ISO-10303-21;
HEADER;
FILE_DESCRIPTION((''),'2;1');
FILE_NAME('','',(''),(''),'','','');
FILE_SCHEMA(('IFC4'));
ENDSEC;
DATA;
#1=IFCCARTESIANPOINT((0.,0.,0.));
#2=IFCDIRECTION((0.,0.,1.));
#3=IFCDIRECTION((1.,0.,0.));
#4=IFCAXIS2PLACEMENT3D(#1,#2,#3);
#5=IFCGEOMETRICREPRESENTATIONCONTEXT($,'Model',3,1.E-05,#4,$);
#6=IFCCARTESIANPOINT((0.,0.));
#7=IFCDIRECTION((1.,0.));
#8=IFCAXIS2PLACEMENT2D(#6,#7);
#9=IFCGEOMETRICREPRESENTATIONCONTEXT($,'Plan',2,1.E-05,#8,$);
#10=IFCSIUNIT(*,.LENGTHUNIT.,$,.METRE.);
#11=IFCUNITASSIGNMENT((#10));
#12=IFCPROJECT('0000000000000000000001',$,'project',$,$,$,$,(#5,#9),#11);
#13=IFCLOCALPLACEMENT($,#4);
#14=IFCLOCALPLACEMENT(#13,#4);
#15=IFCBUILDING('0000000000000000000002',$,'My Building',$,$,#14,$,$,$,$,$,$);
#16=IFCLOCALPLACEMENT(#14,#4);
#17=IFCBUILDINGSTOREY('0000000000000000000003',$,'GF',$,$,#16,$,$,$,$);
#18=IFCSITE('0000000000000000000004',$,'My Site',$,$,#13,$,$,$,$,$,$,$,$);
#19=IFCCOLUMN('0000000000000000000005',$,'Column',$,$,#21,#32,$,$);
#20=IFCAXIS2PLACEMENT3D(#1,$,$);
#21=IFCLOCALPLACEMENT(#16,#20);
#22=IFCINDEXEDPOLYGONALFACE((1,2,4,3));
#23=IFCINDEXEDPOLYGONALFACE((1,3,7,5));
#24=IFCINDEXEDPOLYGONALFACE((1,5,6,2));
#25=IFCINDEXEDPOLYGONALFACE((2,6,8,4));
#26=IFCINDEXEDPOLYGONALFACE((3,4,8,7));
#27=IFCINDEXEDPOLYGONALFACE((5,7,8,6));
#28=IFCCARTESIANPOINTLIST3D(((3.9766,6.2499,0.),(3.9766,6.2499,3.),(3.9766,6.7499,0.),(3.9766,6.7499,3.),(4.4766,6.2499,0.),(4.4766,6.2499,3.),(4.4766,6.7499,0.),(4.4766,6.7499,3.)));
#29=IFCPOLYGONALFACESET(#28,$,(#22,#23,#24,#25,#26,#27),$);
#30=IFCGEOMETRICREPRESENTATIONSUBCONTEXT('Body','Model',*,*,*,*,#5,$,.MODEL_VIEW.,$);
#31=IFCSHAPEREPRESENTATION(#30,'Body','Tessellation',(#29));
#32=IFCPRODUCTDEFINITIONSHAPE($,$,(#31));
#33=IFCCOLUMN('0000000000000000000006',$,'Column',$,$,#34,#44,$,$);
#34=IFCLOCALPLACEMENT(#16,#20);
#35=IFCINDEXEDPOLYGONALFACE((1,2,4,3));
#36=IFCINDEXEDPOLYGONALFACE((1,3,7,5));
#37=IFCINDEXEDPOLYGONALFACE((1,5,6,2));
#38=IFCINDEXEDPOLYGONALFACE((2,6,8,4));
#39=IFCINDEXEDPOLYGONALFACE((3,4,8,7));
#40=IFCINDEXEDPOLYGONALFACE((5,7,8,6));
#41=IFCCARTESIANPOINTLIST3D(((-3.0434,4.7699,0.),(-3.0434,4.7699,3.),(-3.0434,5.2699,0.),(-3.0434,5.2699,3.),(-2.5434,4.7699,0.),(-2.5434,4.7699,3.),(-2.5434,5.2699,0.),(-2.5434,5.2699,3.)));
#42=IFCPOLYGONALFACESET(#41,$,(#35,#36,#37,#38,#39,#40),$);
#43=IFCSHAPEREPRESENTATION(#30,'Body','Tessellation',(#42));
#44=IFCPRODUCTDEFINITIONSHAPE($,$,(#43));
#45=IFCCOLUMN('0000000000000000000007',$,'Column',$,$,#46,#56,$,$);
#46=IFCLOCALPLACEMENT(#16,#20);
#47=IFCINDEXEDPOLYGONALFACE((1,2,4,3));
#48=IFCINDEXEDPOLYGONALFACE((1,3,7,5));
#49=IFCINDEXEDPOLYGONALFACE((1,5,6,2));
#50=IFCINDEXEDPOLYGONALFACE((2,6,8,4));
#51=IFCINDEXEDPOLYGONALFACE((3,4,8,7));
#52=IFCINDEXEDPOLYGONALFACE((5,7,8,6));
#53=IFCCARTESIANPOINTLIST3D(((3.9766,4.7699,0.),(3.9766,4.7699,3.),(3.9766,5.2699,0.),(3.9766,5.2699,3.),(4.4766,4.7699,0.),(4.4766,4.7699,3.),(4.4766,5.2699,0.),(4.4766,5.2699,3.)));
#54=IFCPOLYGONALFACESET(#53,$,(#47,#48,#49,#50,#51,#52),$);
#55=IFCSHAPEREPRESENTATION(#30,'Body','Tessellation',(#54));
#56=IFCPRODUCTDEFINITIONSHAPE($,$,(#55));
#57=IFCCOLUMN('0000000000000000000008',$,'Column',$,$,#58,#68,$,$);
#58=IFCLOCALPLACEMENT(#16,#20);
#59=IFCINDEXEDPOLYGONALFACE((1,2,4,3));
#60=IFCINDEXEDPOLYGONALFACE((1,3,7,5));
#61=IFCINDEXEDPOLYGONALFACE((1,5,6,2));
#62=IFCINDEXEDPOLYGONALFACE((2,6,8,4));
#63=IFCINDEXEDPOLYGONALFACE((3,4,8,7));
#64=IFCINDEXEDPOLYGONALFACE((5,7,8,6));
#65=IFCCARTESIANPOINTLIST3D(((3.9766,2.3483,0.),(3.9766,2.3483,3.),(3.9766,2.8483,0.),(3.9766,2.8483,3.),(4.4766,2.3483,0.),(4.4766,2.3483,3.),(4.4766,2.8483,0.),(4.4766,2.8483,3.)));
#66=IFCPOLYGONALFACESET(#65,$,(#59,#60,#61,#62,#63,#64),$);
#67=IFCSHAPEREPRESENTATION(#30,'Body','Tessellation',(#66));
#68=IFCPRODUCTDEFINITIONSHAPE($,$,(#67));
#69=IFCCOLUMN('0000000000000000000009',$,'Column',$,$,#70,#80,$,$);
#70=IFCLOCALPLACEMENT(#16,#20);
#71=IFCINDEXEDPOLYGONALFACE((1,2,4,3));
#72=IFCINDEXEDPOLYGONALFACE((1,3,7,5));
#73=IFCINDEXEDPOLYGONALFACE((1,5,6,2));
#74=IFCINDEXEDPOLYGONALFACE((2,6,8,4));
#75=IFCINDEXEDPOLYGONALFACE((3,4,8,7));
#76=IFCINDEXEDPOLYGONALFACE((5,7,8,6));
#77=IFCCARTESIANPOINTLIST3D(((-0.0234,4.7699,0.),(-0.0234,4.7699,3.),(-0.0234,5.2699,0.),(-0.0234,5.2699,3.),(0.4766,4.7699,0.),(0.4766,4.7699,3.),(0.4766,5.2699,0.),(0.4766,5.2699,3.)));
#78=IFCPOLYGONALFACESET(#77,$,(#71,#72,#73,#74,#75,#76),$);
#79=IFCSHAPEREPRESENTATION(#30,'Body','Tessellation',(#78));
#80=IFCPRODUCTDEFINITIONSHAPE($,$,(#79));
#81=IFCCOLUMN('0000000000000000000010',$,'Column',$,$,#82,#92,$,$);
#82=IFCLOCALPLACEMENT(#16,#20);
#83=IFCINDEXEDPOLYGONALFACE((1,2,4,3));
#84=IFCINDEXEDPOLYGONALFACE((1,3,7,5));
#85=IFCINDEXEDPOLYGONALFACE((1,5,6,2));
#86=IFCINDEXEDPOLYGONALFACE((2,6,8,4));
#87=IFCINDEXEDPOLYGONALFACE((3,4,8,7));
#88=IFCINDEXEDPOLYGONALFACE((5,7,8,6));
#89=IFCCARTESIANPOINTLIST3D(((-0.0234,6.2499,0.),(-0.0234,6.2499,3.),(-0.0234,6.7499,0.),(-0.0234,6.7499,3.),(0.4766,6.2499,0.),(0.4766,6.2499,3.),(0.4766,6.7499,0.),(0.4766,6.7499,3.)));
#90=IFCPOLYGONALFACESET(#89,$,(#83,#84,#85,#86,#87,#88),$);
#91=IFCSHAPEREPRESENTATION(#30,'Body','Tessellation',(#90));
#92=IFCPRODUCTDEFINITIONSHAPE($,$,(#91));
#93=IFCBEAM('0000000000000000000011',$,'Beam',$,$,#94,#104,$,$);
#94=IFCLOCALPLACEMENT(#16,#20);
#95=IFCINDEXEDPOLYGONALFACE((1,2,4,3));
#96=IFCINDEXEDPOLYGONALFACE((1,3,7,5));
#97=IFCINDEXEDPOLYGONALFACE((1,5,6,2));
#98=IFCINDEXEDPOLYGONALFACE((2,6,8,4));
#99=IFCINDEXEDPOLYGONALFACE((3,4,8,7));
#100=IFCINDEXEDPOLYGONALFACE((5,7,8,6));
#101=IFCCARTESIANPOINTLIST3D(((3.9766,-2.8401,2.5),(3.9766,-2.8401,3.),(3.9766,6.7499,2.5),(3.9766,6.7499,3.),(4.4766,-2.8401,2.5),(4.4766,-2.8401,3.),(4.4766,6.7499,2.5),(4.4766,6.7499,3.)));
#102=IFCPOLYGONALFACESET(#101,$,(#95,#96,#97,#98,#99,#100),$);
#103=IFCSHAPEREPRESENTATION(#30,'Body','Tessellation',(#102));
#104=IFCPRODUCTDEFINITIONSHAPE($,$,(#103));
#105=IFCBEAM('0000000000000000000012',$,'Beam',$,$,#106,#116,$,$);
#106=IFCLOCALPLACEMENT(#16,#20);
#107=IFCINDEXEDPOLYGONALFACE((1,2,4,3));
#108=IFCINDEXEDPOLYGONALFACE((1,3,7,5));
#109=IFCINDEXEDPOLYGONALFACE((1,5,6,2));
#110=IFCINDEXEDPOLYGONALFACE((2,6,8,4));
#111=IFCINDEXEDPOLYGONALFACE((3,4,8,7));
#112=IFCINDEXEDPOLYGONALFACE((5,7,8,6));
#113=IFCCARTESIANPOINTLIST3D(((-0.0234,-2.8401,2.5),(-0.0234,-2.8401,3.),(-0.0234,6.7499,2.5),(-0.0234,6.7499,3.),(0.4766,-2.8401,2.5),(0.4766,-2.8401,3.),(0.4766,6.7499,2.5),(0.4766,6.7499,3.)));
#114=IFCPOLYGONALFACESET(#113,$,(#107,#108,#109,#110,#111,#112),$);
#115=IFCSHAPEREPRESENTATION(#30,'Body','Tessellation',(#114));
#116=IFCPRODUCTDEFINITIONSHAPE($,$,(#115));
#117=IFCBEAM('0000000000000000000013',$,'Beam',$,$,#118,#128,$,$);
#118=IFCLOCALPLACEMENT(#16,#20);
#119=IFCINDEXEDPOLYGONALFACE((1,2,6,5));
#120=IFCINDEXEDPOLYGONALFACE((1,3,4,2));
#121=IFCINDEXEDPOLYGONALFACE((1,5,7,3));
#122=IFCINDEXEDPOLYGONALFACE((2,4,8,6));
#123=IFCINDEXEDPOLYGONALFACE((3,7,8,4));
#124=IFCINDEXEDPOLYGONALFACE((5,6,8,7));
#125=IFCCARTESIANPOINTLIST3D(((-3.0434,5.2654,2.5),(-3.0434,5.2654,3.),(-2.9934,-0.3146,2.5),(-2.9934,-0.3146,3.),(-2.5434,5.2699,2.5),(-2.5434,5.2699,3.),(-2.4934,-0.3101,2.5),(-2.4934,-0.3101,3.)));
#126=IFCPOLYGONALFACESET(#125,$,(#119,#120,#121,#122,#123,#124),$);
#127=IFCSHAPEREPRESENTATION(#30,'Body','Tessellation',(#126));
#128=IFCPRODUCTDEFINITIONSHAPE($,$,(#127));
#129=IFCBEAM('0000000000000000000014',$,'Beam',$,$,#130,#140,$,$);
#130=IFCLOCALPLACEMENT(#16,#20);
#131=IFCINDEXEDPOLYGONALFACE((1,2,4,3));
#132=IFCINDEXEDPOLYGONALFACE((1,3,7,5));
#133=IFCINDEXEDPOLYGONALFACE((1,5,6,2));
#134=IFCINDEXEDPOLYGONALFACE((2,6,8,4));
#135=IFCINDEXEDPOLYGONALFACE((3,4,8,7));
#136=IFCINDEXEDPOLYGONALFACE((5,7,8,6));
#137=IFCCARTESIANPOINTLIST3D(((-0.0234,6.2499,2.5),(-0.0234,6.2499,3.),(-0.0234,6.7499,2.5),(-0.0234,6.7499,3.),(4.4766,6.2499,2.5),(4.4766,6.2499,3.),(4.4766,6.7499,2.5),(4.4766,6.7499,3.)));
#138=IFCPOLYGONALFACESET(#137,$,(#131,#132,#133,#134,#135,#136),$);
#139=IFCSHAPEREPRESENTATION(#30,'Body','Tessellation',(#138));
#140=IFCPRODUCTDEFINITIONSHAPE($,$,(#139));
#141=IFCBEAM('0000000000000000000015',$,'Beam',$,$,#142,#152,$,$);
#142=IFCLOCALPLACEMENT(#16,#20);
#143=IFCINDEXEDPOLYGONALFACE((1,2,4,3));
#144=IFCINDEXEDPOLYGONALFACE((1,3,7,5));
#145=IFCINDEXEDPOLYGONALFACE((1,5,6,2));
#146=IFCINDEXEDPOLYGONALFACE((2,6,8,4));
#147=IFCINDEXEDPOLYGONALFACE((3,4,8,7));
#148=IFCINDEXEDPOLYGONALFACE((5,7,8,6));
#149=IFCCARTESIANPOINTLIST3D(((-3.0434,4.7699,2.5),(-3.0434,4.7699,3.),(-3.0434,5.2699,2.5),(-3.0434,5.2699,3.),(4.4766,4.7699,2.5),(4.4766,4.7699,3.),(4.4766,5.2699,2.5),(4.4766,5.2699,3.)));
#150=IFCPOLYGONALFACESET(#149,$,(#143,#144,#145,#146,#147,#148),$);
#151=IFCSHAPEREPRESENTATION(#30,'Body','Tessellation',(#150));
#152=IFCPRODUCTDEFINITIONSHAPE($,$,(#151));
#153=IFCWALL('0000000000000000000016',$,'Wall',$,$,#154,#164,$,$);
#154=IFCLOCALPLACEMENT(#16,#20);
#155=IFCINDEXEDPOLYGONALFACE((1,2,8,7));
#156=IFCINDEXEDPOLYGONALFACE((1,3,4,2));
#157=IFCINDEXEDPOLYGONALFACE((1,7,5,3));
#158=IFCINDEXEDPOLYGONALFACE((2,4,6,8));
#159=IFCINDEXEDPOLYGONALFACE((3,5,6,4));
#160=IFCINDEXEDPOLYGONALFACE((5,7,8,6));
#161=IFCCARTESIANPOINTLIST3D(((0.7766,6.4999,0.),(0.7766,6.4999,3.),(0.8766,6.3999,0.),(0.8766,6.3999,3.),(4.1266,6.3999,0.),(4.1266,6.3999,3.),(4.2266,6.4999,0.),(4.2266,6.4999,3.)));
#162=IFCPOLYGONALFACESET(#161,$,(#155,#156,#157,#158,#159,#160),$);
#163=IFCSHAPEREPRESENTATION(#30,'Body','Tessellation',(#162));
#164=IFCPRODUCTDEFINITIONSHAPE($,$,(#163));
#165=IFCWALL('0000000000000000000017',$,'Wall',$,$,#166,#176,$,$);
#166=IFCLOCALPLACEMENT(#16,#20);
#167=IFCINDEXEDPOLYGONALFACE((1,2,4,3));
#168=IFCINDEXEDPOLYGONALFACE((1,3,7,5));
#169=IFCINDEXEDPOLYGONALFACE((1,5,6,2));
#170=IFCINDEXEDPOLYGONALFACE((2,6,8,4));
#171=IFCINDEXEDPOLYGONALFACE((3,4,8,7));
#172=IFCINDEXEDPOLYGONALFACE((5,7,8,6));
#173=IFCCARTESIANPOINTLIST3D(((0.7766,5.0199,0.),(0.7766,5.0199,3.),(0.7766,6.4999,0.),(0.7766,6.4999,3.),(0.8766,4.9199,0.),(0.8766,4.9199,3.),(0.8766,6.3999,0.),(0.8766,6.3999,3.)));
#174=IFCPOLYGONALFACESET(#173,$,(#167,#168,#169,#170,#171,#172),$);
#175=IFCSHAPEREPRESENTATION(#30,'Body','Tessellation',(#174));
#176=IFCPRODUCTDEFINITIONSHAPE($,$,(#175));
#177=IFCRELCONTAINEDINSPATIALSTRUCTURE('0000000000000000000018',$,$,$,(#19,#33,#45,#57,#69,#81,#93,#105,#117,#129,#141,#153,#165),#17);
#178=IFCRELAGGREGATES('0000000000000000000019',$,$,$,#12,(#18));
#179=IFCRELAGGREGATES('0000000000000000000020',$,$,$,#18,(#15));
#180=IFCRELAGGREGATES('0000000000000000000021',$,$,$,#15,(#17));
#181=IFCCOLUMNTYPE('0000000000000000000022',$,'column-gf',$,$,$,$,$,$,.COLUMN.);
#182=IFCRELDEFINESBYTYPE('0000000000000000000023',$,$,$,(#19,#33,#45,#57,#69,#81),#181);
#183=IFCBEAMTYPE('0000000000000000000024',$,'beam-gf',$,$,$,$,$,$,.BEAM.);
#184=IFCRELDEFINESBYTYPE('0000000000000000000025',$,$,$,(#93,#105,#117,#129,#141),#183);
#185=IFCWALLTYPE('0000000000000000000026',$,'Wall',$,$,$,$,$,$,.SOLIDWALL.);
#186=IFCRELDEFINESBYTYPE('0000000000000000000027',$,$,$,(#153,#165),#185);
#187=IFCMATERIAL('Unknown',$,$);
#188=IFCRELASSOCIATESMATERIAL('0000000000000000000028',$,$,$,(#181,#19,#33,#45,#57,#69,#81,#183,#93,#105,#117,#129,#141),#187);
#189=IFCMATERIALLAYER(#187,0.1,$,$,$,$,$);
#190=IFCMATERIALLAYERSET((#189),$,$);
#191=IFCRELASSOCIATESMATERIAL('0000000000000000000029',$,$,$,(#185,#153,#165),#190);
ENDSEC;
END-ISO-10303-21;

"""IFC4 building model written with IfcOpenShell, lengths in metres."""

from ifc_helpers import new_model, si_unit, frame, origin_with_axes, origin_2d_with_axis, place, context, subcontext, project, spatial, line, indexed_curve, rectangle, outline, extrude, material, layer, layer_set, layer_usage, material_profile, profile_set, profile_usage, type_object, element, save


model = new_model("IFC4")

# Units and contexts
model_context = context("Model", 3, precision=1e-05, world=origin_with_axes())
plan_context = context("Plan", 2, precision=1e-05, world=origin_2d_with_axis())
body_context_1 = subcontext(model_context, "Body", "Model", "MODEL_VIEW")
ifc_project = project(units=[si_unit("LENGTHUNIT", "METRE")], contexts=[model_context, plan_context])

# Site, building, storey
site_placement = place(None, origin_with_axes())
site = spatial("IfcSite", under=ifc_project, at=site_placement, Name="My Site")
building_placement = place(site_placement, origin_with_axes())
building = spatial("IfcBuilding", under=site, at=building_placement, Name="My Building")
storey_placement = place(building_placement, origin_with_axes())
storey = spatial("IfcBuildingStorey", under=building, at=storey_placement, Name="GF")

# Columns
ifc_material_1 = material(Name="Unknown")
ifc_material_profile_1 = material_profile(ifc_material_1, rectangle(XDim=0.5, YDim=0.5))
ifc_profile_set_1 = profile_set([ifc_material_profile_1])
ifc_profile_usage_1 = profile_usage(ifc_profile_set_1, cardinal=5)
column_type = type_object("IfcColumnType", Name="column-gf", PredefinedType="COLUMN", material=ifc_profile_set_1)
column_1_placement = place(storey_placement, frame((4.2266, 6.4999, 0.0), z_axis=(0.0, 0.0, 1.0), x_axis=(1.0, 0.0, 0.0)))
element("IfcColumn", 1, at=column_1_placement, inside=storey, type_object=column_type, material=ifc_profile_usage_1, Name="Column", context=body_context_1, shape_type="SweptSolid", body=[
    extrude(rectangle(XDim=0.5, YDim=0.5), origin_with_axes(), (0.0, 0.0, 1.0), 3.0),
])
ifc_profile_usage_2 = profile_usage(ifc_profile_set_1, cardinal=5)
column_2_placement = place(storey_placement, frame((-2.7934, 5.0199, 0.0), z_axis=(0.0, 0.0, 1.0), x_axis=(1.0, 0.0, 0.0)))
element("IfcColumn", 2, at=column_2_placement, inside=storey, type_object=column_type, material=ifc_profile_usage_2, Name="Column", context=body_context_1, shape_type="SweptSolid", body=[
    extrude(rectangle(XDim=0.5, YDim=0.5), origin_with_axes(), (0.0, 0.0, 1.0), 3.0),
])
ifc_profile_usage_3 = profile_usage(ifc_profile_set_1, cardinal=5)
column_3_placement = place(storey_placement, frame((4.2266, 5.0199, 0.0), z_axis=(0.0, 0.0, 1.0), x_axis=(1.0, 0.0, 0.0)))
element("IfcColumn", 3, at=column_3_placement, inside=storey, type_object=column_type, material=ifc_profile_usage_3, Name="Column", context=body_context_1, shape_type="SweptSolid", body=[
    extrude(rectangle(XDim=0.5, YDim=0.5), origin_with_axes(), (0.0, 0.0, 1.0), 3.0),
])
ifc_profile_usage_4 = profile_usage(ifc_profile_set_1, cardinal=5)
column_4_placement = place(storey_placement, frame((4.2266, 2.5983, 0.0), z_axis=(0.0, 0.0, 1.0), x_axis=(1.0, 0.0, 0.0)))
element("IfcColumn", 4, at=column_4_placement, inside=storey, type_object=column_type, material=ifc_profile_usage_4, Name="Column", context=body_context_1, shape_type="SweptSolid", body=[
    extrude(rectangle(XDim=0.5, YDim=0.5), origin_with_axes(), (0.0, 0.0, 1.0), 3.0),
])
ifc_profile_usage_5 = profile_usage(ifc_profile_set_1, cardinal=5)
column_5_placement = place(storey_placement, frame((0.2266, 5.0199, 0.0), z_axis=(0.0, 0.0, 1.0), x_axis=(1.0, 0.0, 0.0)))
element("IfcColumn", 5, at=column_5_placement, inside=storey, type_object=column_type, material=ifc_profile_usage_5, Name="Column", context=body_context_1, shape_type="SweptSolid", body=[
    extrude(rectangle(XDim=0.5, YDim=0.5), origin_with_axes(), (0.0, 0.0, 1.0), 3.0),
])
ifc_profile_usage_6 = profile_usage(ifc_profile_set_1, cardinal=5)
column_6_placement = place(storey_placement, frame((0.2266, 6.4999, 0.0), z_axis=(0.0, 0.0, 1.0), x_axis=(1.0, 0.0, 0.0)))
element("IfcColumn", 6, at=column_6_placement, inside=storey, type_object=column_type, material=ifc_profile_usage_6, Name="Column", context=body_context_1, shape_type="SweptSolid", body=[
    extrude(rectangle(XDim=0.5, YDim=0.5), origin_with_axes(), (0.0, 0.0, 1.0), 3.0),
])

# Beams
ifc_material_profile_2 = material_profile(ifc_material_1, rectangle(XDim=0.5, YDim=0.5))
ifc_profile_set_2 = profile_set([ifc_material_profile_2])
ifc_profile_usage_7 = profile_usage(ifc_profile_set_2, cardinal=7)
beam_type = type_object("IfcBeamType", Name="beam-gf", PredefinedType="BEAM", material=ifc_profile_set_2)
beam_1_placement = place(storey_placement, frame((4.4766, 6.7499, 3.0), z_axis=(0.0, -1.0, 0.0), x_axis=(1.0, 0.0, 0.0)))
element("IfcBeam", 7, at=beam_1_placement, inside=storey, type_object=beam_type, material=ifc_profile_usage_7, Name="Beam", context=body_context_1, shape_type="SweptSolid", body=[
    extrude(rectangle(XDim=0.5, YDim=0.5), frame((-0.25, -0.25, 0.0), z_axis=(0.0, 0.0, 1.0), x_axis=(1.0, 0.0, 0.0)), (0.0, 0.0, 1.0), 9.59),
])
ifc_profile_usage_8 = profile_usage(ifc_profile_set_2, cardinal=7)
beam_2_placement = place(storey_placement, frame((0.4766, 6.7499, 3.0), z_axis=(0.0, -1.0, 0.0), x_axis=(1.0, 0.0, 0.0)))
element("IfcBeam", 8, at=beam_2_placement, inside=storey, type_object=beam_type, material=ifc_profile_usage_8, Name="Beam", context=body_context_1, shape_type="SweptSolid", body=[
    extrude(rectangle(XDim=0.5, YDim=0.5), frame((-0.25, -0.25, 0.0), z_axis=(0.0, 0.0, 1.0), x_axis=(1.0, 0.0, 0.0)), (0.0, 0.0, 1.0), 9.59),
])
ifc_profile_usage_9 = profile_usage(ifc_profile_set_2, cardinal=7)
beam_3_placement = place(storey_placement, frame((-2.5434, 5.2699, 3.0), z_axis=(0.00896, -0.99996, 0.0), x_axis=(0.99996, 0.00896, 0.0)))
element("IfcBeam", 9, at=beam_3_placement, inside=storey, type_object=beam_type, material=ifc_profile_usage_9, Name="Beam", context=body_context_1, shape_type="SweptSolid", body=[
    extrude(rectangle(XDim=0.5, YDim=0.5), frame((-0.25, -0.25, 0.0), z_axis=(0.0, 0.0, 1.0), x_axis=(1.0, 0.0, 0.0)), (0.0, 0.0, 1.0), 5.5802),
])
ifc_profile_usage_10 = profile_usage(ifc_profile_set_2, cardinal=7)
beam_4_placement = place(storey_placement, frame((-0.0234, 6.7499, 3.0), z_axis=(1.0, -0.000001, 0.000001), x_axis=(0.000001, 1.0, 0.0)))
element("IfcBeam", 10, at=beam_4_placement, inside=storey, type_object=beam_type, material=ifc_profile_usage_10, Name="Beam", context=body_context_1, shape_type="SweptSolid", body=[
    extrude(rectangle(XDim=0.5, YDim=0.5), frame((-0.25, -0.25, 0.0), z_axis=(0.0, 0.0, 1.0), x_axis=(1.0, 0.0, 0.0)), (0.0, 0.0, 1.0), 4.5),
])
ifc_profile_usage_11 = profile_usage(ifc_profile_set_2, cardinal=7)
beam_5_placement = place(storey_placement, frame((4.4766, 4.7699, 3.0), z_axis=(-1.0, 0.0, 0.0), x_axis=(0.0, -1.0, 0.0)))
element("IfcBeam", 11, at=beam_5_placement, inside=storey, type_object=beam_type, material=ifc_profile_usage_11, Name="Beam", context=body_context_1, shape_type="SweptSolid", body=[
    extrude(rectangle(XDim=0.5, YDim=0.5), frame((-0.25, -0.25, 0.0), z_axis=(0.0, 0.0, 1.0), x_axis=(1.0, 0.0, 0.0)), (0.0, 0.0, 1.0), 7.52),
])

# Walls
ifc_layer_1 = layer(ifc_material_1, 0.1)
ifc_layer_set_1 = layer_set([ifc_layer_1])
ifc_layer_usage_1 = layer_usage(ifc_layer_set_1, "AXIS2", "POSITIVE", 0.0)
wall_type = type_object("IfcWallType", Name="Wall", PredefinedType="SOLIDWALL", material=ifc_layer_set_1)
wall_1_placement = place(storey_placement, frame((4.2266, 6.4999, 0.0), z_axis=(0.0, 0.0, 1.0), x_axis=(-1.0, 0.0, 0.0)))
element("IfcWall", 12, at=wall_1_placement, inside=storey, type_object=wall_type, material=ifc_layer_usage_1, Name="Wall", context=body_context_1, shape_type="SweptSolid", body=[
    extrude(outline(indexed_curve([(0.0, 0.0), (0.1, 0.1), (3.35, 0.1), (3.45, 0.0)], segments=[line(1, 2, 3, 4, 1)])), origin_with_axes(), (0.0, 0.0, 1.0), 3.0),
])
ifc_layer_usage_2 = layer_usage(ifc_layer_set_1, "AXIS2", "POSITIVE", 0.0)
wall_2_placement = place(storey_placement, frame((0.7766, 6.4999, 0.0), z_axis=(0.0, 0.0, 1.0), x_axis=(0.0, -1.0, 0.0)))
element("IfcWall", 13, at=wall_2_placement, inside=storey, type_object=wall_type, material=ifc_layer_usage_2, Name="Wall", context=body_context_1, shape_type="SweptSolid", body=[
    extrude(outline(indexed_curve([(0.0, 0.0), (0.1, 0.1), (1.58, 0.1), (1.48, 0.0)], segments=[line(1, 2, 3, 4, 1)])), origin_with_axes(), (0.0, 0.0, 1.0), 3.0),
])

save(model, "model.ifc")
